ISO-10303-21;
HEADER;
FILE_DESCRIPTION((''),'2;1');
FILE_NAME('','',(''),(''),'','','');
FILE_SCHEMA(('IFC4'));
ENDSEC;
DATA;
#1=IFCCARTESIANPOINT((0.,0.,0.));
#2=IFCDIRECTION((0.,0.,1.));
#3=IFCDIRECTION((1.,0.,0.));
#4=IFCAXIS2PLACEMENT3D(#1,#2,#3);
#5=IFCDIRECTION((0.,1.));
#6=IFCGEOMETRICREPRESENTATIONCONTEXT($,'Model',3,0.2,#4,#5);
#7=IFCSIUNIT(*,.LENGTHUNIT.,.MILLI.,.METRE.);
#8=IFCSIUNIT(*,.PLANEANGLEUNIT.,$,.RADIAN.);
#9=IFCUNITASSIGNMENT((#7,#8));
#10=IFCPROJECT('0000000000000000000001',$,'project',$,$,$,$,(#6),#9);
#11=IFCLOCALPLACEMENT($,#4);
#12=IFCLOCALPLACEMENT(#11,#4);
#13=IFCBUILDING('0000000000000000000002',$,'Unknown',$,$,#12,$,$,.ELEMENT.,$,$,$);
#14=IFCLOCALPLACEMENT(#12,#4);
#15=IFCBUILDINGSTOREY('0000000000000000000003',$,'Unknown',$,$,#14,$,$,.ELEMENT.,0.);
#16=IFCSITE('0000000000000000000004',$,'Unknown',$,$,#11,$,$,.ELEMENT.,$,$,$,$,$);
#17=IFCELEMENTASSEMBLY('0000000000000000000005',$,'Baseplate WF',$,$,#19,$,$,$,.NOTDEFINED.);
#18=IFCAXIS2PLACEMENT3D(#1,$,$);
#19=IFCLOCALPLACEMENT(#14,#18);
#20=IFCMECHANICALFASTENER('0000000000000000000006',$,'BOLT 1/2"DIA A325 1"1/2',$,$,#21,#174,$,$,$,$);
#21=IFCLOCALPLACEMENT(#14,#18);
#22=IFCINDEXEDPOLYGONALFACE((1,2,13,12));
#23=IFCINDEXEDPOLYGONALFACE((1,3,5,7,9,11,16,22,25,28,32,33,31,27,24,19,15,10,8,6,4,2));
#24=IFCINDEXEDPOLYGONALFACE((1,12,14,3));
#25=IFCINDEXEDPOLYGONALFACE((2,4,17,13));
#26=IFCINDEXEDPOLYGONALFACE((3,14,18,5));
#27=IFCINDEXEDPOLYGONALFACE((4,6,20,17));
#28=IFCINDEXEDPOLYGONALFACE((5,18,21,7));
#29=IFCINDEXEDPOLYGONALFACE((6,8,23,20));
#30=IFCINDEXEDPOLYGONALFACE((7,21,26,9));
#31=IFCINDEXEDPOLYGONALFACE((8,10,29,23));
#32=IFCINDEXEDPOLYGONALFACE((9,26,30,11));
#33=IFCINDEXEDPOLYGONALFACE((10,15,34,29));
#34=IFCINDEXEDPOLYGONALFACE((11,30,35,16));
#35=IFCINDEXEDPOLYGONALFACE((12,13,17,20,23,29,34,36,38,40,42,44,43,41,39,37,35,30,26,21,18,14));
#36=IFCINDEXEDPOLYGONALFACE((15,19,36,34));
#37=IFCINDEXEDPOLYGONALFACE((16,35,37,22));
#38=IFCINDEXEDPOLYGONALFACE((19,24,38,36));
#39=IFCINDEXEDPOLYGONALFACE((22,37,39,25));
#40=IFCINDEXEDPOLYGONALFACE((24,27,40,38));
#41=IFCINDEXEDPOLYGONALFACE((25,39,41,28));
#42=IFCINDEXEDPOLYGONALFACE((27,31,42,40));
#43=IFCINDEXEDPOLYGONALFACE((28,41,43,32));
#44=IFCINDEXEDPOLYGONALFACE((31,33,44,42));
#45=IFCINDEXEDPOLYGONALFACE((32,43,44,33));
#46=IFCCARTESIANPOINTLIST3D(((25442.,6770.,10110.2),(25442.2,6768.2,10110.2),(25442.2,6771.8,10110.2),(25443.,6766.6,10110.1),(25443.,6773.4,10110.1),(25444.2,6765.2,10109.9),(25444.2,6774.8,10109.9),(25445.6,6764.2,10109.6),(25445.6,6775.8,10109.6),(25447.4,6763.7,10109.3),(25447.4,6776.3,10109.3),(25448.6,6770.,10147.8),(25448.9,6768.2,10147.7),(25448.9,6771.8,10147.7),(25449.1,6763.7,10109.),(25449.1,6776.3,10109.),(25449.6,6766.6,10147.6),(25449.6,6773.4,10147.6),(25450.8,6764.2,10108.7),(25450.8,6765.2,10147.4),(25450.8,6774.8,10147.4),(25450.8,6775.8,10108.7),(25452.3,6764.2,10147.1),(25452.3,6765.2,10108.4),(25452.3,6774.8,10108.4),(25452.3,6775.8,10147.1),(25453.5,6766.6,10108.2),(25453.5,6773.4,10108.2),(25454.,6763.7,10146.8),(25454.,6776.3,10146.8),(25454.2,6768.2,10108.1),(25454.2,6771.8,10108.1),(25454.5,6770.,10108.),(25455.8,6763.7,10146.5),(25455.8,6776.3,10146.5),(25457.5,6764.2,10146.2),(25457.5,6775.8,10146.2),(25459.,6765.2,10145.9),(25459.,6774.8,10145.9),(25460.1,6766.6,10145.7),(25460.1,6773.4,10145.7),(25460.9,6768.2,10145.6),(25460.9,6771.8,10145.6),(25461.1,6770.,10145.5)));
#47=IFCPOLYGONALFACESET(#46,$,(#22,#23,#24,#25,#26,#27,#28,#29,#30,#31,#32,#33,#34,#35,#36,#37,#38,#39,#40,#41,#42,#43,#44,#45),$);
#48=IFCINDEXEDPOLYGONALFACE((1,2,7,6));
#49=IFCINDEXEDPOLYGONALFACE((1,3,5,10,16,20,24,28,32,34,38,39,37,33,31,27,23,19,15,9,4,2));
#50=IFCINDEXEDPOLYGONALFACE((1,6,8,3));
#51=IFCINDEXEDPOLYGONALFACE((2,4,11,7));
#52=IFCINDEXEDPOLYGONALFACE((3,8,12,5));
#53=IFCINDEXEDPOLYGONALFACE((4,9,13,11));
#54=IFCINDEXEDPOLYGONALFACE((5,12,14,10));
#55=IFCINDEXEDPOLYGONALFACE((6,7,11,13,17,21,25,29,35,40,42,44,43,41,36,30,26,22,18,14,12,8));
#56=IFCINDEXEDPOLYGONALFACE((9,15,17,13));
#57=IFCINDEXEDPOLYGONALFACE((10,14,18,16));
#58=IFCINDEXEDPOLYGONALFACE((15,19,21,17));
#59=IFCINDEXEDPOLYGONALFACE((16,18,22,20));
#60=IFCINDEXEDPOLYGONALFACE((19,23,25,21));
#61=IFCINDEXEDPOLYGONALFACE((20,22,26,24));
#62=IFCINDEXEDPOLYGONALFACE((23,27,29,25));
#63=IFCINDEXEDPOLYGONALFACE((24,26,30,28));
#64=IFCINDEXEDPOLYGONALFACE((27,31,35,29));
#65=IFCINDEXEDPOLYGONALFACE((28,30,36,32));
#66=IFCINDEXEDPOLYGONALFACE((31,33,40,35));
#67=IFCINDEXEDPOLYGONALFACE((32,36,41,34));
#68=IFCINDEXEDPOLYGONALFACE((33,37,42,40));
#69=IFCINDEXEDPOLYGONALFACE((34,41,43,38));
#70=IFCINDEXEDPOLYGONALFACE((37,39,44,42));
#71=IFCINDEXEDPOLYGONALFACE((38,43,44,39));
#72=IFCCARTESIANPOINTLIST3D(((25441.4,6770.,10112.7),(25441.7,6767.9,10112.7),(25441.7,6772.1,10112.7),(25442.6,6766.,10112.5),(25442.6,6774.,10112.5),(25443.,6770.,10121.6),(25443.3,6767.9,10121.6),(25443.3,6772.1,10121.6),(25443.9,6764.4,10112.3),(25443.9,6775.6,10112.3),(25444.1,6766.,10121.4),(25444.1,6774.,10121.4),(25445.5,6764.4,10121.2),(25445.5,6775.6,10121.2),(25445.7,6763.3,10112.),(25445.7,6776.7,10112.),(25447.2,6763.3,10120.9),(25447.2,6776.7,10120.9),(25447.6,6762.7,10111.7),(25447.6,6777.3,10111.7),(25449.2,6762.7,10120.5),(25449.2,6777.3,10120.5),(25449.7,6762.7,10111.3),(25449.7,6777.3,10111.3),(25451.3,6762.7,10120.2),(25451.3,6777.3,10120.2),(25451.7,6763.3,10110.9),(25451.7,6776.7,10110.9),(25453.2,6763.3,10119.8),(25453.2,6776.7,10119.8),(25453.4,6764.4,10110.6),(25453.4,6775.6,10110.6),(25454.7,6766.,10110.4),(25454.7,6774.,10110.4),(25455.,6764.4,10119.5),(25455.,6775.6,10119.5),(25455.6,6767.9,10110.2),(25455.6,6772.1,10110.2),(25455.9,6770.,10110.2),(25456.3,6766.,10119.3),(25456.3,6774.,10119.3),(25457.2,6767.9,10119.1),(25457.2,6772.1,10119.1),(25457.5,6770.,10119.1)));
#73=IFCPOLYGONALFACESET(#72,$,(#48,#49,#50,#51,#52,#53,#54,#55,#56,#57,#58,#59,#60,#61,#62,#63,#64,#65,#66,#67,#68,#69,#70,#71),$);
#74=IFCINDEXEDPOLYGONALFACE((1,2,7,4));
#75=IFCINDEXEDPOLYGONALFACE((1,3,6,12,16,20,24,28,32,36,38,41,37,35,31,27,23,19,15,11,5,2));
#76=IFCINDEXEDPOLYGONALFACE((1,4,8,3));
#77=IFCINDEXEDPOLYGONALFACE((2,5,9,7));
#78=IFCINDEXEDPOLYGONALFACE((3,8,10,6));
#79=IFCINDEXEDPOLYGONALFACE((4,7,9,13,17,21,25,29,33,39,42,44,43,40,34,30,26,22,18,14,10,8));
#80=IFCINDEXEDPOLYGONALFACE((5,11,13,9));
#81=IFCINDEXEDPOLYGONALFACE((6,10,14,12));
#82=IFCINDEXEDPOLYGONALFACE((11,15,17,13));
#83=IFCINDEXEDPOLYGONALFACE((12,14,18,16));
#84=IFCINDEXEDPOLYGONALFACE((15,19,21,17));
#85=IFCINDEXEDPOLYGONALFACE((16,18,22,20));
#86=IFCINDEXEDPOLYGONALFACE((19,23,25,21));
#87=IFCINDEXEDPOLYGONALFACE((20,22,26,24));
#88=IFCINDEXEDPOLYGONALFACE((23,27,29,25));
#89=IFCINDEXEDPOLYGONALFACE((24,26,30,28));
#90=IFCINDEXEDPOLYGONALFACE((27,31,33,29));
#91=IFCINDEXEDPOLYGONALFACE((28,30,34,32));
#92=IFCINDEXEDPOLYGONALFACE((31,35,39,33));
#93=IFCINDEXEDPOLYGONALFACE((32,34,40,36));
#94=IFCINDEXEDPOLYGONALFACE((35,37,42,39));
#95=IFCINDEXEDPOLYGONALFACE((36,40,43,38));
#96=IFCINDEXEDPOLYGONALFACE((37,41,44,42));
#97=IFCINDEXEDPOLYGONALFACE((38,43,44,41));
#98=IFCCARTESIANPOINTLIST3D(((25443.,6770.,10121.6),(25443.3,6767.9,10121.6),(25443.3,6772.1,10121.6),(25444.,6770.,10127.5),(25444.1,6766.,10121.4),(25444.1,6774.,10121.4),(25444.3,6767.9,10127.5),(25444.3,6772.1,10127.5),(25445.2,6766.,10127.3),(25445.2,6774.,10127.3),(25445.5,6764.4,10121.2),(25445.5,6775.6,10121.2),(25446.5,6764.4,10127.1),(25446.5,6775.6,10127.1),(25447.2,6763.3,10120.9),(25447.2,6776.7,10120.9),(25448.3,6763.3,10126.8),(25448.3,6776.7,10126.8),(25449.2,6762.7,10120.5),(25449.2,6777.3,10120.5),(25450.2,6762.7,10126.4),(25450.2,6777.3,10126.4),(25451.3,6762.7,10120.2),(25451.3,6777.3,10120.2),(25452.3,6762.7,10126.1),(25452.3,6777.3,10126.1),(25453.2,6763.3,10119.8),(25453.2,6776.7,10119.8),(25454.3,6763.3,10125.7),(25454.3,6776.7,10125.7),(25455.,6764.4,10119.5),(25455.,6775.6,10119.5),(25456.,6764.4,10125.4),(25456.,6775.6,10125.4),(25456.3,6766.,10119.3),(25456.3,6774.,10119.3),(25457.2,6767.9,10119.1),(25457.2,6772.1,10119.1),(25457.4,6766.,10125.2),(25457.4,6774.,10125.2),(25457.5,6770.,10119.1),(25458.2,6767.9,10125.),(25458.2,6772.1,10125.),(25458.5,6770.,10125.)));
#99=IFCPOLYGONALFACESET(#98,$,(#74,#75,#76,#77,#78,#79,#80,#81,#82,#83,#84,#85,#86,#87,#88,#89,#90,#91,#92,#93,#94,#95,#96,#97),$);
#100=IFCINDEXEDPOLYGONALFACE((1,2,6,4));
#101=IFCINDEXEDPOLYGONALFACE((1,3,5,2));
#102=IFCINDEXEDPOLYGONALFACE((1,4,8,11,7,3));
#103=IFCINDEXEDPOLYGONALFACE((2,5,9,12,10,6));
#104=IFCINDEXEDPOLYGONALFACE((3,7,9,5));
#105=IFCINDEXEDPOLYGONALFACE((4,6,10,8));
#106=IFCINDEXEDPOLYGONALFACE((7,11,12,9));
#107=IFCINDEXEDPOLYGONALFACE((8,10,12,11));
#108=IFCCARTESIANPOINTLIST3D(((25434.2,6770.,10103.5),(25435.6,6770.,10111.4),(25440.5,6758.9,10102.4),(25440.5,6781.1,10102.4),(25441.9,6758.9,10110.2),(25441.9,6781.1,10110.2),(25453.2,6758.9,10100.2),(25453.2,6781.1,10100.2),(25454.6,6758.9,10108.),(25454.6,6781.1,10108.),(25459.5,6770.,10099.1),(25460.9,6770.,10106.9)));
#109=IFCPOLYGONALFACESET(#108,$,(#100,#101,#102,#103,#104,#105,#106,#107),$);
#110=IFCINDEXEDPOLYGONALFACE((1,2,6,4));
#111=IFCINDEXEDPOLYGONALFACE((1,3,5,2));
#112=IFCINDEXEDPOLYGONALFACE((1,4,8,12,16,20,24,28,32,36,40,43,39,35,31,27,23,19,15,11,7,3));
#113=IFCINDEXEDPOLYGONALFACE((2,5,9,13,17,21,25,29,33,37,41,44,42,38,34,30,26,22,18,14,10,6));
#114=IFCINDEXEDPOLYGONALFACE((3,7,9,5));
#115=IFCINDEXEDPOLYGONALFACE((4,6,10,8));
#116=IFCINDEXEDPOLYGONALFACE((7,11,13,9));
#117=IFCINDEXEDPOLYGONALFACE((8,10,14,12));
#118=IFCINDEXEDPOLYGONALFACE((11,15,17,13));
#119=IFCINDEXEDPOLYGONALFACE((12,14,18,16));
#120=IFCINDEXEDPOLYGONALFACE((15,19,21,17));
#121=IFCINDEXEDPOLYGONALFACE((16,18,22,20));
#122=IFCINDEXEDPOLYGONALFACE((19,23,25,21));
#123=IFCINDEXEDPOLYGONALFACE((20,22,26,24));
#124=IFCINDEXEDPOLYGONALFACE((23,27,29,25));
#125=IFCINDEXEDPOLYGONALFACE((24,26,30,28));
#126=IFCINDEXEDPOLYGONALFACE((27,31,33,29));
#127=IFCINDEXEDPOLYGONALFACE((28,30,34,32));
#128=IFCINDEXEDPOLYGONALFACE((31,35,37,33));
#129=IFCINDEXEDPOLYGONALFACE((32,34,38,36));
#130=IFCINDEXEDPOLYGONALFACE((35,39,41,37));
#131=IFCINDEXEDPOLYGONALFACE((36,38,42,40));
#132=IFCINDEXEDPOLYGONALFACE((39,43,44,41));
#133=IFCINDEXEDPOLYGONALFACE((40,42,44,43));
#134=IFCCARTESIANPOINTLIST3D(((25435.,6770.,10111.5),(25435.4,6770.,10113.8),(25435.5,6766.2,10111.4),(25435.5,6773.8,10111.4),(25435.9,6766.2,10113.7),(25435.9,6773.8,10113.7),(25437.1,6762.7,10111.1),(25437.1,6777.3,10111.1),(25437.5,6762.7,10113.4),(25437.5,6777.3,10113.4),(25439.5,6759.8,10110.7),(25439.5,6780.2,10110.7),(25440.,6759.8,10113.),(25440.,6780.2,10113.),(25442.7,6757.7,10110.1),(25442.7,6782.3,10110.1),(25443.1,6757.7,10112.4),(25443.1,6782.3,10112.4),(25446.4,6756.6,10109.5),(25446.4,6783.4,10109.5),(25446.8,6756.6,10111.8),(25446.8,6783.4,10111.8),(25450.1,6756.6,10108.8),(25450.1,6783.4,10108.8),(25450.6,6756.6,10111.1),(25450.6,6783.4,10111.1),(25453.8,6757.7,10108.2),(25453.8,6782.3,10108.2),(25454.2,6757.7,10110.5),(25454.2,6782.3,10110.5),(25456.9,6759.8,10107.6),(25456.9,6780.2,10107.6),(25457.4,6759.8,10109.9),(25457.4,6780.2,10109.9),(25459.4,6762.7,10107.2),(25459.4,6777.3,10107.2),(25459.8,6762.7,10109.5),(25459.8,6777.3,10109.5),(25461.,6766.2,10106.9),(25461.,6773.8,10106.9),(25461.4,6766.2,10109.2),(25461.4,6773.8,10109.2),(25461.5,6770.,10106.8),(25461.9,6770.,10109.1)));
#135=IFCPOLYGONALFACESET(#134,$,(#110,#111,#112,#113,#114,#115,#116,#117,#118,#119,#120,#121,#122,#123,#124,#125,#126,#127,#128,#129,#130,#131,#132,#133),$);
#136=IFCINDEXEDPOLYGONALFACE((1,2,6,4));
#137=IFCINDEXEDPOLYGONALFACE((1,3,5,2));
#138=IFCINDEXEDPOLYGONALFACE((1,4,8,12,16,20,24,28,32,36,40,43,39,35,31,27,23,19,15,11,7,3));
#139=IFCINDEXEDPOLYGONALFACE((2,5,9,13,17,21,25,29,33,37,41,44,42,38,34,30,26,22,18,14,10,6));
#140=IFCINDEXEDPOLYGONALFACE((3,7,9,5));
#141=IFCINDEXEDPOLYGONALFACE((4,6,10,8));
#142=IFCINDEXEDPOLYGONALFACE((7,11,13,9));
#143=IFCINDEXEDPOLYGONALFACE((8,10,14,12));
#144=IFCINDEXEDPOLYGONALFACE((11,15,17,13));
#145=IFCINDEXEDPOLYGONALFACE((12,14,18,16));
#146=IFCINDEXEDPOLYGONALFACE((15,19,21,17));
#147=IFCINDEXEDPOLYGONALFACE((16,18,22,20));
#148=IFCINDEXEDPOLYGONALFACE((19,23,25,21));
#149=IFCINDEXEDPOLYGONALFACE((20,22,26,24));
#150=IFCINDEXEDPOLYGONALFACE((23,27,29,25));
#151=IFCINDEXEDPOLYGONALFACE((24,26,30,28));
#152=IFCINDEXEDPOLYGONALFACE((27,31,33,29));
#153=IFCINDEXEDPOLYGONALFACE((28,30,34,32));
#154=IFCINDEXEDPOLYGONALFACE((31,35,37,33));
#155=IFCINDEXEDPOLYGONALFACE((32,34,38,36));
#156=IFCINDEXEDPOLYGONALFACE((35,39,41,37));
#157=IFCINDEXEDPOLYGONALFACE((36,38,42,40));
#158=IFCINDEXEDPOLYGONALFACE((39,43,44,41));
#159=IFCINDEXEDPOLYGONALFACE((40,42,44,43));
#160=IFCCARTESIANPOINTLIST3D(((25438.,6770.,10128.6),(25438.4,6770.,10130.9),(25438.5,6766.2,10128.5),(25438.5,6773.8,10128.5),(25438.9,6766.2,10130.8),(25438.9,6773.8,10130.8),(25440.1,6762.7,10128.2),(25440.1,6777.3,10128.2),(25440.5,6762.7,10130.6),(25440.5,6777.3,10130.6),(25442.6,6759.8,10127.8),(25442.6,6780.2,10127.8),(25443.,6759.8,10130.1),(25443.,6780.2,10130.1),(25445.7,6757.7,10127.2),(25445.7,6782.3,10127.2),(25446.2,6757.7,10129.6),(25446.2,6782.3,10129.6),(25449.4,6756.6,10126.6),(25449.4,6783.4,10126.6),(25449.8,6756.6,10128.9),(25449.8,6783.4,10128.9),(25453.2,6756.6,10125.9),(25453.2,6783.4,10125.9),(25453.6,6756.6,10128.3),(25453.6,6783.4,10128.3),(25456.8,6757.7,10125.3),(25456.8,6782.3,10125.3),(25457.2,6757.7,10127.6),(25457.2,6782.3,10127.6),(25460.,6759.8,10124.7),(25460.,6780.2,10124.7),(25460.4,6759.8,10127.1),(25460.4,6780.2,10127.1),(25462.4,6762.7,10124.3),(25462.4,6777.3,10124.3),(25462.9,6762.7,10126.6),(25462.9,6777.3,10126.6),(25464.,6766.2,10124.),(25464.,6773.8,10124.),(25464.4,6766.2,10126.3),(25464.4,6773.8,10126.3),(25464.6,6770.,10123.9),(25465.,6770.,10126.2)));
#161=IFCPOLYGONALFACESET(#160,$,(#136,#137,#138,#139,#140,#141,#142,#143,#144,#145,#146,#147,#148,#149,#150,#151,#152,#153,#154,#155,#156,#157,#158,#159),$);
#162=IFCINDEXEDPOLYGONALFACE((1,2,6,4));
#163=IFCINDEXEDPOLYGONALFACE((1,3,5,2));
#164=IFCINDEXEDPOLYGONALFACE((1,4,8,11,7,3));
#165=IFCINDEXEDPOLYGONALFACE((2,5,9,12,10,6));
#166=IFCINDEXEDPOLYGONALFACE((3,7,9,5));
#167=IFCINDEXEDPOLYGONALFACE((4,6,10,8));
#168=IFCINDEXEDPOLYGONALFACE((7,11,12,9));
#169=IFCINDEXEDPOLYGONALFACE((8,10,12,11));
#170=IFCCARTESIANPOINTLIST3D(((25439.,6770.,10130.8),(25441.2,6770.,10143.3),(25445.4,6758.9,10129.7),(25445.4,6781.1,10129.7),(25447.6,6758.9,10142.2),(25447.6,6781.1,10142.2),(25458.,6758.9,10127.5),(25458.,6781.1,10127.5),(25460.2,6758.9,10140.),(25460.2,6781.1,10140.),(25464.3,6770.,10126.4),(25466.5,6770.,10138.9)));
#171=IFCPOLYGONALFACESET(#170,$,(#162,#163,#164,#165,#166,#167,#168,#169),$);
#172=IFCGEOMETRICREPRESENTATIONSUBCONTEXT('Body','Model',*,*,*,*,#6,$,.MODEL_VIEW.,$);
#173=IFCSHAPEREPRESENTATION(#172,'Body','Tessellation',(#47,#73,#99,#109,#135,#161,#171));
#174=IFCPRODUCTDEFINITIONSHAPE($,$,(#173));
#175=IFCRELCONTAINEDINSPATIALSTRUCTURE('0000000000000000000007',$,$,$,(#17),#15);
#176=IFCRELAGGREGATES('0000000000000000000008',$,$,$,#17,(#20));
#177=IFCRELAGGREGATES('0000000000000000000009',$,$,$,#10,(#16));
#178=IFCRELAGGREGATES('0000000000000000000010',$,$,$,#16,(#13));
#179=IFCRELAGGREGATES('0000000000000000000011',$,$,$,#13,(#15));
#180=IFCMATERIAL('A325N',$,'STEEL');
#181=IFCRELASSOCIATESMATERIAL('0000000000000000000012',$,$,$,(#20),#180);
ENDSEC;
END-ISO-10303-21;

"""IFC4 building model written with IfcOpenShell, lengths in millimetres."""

from ifc_helpers import new_model, si_unit, direction, frame, origin_with_axes, place, context, subcontext, project, spatial, line, arc, indexed_curve, outline, extrude, source, transform, mapped, material, element, aggregate, save


model = new_model("IFC4")

# Units and contexts
model_context = context("Model", 3, precision=0.2, world=origin_with_axes(), true_north=direction((0.0, 1.0)))
body_context = subcontext(model_context, "Body", "Model", "MODEL_VIEW")
ifc_project = project(units=[si_unit("LENGTHUNIT", "METRE", prefix="MILLI"), si_unit("PLANEANGLEUNIT", "RADIAN")], contexts=[model_context])

# Site, building, storey
site_placement = place(None, origin_with_axes())
site = spatial("IfcSite", under=ifc_project, at=site_placement, Name="Unknown", CompositionType="ELEMENT")
building_placement = place(site_placement, origin_with_axes())
building = spatial("IfcBuilding", under=site, at=building_placement, Name="Unknown", CompositionType="ELEMENT")
storey_placement = place(building_placement, origin_with_axes())
storey = spatial("IfcBuildingStorey", under=building, at=storey_placement, Name="Unknown", CompositionType="ELEMENT", Elevation=0.0)

# Element assembly
assembly_1_placement = place(storey_placement, frame((25480.3, 6800.0, 10118.1), z_axis=(-0.173648, 0.0, -0.984808), x_axis=(0.0, -1.0, 0.0)))
assembly_1 = element("IfcElementAssembly", 1, at=assembly_1_placement, inside=storey, Name="Baseplate WF", PredefinedType="NOTDEFINED")

# Mechanical fastener
ifc_material_1 = material(Name="A325N", Category="STEEL")
shared_shape_1 = source(origin_with_axes(), body_context, "Body", "SweptSolid", [
    extrude(outline(indexed_curve([(6.3, 0.0), (0.0, 6.3), (-6.3, 0.0), (0.0, -6.3)], segments=[arc(1, 2, 3), arc(3, 4, 1)])), frame((0.0, 0.0, 17.4), z_axis=(0.0, 0.0, -1.0), x_axis=(0.0, 1.0, 0.0)), (0.0, 0.0, 1.0), 38.1),
    extrude(outline(indexed_curve([(7.3, 0.0), (0.0, 7.3), (-7.3, 0.0), (0.0, -7.3)], segments=[arc(1, 2, 3), arc(3, 4, 1)])), frame((0.0, 0.0, 15.0), z_axis=(0.0, 0.0, -1.0), x_axis=(0.0, 1.0, 0.0)), (0.0, 0.0, 1.0), 9.0),
    extrude(outline(indexed_curve([(7.3, 0.0), (0.0, 7.3), (-7.3, 0.0), (0.0, -7.3)], segments=[arc(1, 2, 3), arc(3, 4, 1)])), frame((0.0, 0.0, 6.0), z_axis=(0.0, 0.0, -1.0), x_axis=(0.0, 1.0, 0.0)), (0.0, 0.0, 1.0), 6.0),
    extrude(outline(indexed_curve([(12.8, 0.0), (6.4, 11.1), (-6.4, 11.1), (-12.8, 0.0), (-6.4, -11.1), (6.4, -11.1)], segments=[line(1, 2, 3, 4, 5, 6, 1)])), frame((0.0, 0.0, 25.3), z_axis=(0.0, 0.0, -1.0), x_axis=(0.0, 1.0, 0.0)), (0.0, 0.0, 1.0), 7.9),
    extrude(outline(indexed_curve([(13.5, 0.0), (0.0, 13.5), (-13.5, 0.0), (0.0, -13.5)], segments=[arc(1, 2, 3), arc(3, 4, 1)])), frame((0.0, 0.0, 17.4), z_axis=(0.0, 0.0, -1.0), x_axis=(0.0, 1.0, 0.0)), (0.0, 0.0, 1.0), 2.4),
    extrude(outline(indexed_curve([(13.5, 0.0), (0.0, 13.5), (-13.5, 0.0), (0.0, -13.5)], segments=[arc(1, 2, 3), arc(3, 4, 1)])), frame((0.0, 0.0, 0.0), z_axis=(0.0, 0.0, -1.0), x_axis=(0.0, 1.0, 0.0)), (0.0, 0.0, 1.0), 2.4),
    extrude(outline(indexed_curve([(12.8, 0.0), (6.4, 11.1), (-6.4, 11.1), (-12.8, 0.0), (-6.4, -11.1), (6.4, -11.1)], segments=[line(1, 2, 3, 4, 5, 6, 1)])), frame((0.0, 0.0, -2.4), z_axis=(0.0, 0.0, -1.0), x_axis=(0.0, 1.0, 0.0)), (0.0, 0.0, 1.0), 12.7),
])
mechanical_fastener_1_placement = place(assembly_1_placement, frame((30.0, 30.0, -3.0), z_axis=(0.0, 0.0, 1.0), x_axis=(1.0, 0.0, 0.0)))
mechanical_fastener_1 = element("IfcMechanicalFastener", 2, at=mechanical_fastener_1_placement, material=ifc_material_1, Name="BOLT 1/2\"DIA A325 1\"1/2", context=body_context, shape_type="MappedRepresentation", body=[
    mapped(shared_shape_1, transform((0.0, 0.0, 0.0))),
])
aggregate(assembly_1, [mechanical_fastener_1])

save(model, "model.ifc")
